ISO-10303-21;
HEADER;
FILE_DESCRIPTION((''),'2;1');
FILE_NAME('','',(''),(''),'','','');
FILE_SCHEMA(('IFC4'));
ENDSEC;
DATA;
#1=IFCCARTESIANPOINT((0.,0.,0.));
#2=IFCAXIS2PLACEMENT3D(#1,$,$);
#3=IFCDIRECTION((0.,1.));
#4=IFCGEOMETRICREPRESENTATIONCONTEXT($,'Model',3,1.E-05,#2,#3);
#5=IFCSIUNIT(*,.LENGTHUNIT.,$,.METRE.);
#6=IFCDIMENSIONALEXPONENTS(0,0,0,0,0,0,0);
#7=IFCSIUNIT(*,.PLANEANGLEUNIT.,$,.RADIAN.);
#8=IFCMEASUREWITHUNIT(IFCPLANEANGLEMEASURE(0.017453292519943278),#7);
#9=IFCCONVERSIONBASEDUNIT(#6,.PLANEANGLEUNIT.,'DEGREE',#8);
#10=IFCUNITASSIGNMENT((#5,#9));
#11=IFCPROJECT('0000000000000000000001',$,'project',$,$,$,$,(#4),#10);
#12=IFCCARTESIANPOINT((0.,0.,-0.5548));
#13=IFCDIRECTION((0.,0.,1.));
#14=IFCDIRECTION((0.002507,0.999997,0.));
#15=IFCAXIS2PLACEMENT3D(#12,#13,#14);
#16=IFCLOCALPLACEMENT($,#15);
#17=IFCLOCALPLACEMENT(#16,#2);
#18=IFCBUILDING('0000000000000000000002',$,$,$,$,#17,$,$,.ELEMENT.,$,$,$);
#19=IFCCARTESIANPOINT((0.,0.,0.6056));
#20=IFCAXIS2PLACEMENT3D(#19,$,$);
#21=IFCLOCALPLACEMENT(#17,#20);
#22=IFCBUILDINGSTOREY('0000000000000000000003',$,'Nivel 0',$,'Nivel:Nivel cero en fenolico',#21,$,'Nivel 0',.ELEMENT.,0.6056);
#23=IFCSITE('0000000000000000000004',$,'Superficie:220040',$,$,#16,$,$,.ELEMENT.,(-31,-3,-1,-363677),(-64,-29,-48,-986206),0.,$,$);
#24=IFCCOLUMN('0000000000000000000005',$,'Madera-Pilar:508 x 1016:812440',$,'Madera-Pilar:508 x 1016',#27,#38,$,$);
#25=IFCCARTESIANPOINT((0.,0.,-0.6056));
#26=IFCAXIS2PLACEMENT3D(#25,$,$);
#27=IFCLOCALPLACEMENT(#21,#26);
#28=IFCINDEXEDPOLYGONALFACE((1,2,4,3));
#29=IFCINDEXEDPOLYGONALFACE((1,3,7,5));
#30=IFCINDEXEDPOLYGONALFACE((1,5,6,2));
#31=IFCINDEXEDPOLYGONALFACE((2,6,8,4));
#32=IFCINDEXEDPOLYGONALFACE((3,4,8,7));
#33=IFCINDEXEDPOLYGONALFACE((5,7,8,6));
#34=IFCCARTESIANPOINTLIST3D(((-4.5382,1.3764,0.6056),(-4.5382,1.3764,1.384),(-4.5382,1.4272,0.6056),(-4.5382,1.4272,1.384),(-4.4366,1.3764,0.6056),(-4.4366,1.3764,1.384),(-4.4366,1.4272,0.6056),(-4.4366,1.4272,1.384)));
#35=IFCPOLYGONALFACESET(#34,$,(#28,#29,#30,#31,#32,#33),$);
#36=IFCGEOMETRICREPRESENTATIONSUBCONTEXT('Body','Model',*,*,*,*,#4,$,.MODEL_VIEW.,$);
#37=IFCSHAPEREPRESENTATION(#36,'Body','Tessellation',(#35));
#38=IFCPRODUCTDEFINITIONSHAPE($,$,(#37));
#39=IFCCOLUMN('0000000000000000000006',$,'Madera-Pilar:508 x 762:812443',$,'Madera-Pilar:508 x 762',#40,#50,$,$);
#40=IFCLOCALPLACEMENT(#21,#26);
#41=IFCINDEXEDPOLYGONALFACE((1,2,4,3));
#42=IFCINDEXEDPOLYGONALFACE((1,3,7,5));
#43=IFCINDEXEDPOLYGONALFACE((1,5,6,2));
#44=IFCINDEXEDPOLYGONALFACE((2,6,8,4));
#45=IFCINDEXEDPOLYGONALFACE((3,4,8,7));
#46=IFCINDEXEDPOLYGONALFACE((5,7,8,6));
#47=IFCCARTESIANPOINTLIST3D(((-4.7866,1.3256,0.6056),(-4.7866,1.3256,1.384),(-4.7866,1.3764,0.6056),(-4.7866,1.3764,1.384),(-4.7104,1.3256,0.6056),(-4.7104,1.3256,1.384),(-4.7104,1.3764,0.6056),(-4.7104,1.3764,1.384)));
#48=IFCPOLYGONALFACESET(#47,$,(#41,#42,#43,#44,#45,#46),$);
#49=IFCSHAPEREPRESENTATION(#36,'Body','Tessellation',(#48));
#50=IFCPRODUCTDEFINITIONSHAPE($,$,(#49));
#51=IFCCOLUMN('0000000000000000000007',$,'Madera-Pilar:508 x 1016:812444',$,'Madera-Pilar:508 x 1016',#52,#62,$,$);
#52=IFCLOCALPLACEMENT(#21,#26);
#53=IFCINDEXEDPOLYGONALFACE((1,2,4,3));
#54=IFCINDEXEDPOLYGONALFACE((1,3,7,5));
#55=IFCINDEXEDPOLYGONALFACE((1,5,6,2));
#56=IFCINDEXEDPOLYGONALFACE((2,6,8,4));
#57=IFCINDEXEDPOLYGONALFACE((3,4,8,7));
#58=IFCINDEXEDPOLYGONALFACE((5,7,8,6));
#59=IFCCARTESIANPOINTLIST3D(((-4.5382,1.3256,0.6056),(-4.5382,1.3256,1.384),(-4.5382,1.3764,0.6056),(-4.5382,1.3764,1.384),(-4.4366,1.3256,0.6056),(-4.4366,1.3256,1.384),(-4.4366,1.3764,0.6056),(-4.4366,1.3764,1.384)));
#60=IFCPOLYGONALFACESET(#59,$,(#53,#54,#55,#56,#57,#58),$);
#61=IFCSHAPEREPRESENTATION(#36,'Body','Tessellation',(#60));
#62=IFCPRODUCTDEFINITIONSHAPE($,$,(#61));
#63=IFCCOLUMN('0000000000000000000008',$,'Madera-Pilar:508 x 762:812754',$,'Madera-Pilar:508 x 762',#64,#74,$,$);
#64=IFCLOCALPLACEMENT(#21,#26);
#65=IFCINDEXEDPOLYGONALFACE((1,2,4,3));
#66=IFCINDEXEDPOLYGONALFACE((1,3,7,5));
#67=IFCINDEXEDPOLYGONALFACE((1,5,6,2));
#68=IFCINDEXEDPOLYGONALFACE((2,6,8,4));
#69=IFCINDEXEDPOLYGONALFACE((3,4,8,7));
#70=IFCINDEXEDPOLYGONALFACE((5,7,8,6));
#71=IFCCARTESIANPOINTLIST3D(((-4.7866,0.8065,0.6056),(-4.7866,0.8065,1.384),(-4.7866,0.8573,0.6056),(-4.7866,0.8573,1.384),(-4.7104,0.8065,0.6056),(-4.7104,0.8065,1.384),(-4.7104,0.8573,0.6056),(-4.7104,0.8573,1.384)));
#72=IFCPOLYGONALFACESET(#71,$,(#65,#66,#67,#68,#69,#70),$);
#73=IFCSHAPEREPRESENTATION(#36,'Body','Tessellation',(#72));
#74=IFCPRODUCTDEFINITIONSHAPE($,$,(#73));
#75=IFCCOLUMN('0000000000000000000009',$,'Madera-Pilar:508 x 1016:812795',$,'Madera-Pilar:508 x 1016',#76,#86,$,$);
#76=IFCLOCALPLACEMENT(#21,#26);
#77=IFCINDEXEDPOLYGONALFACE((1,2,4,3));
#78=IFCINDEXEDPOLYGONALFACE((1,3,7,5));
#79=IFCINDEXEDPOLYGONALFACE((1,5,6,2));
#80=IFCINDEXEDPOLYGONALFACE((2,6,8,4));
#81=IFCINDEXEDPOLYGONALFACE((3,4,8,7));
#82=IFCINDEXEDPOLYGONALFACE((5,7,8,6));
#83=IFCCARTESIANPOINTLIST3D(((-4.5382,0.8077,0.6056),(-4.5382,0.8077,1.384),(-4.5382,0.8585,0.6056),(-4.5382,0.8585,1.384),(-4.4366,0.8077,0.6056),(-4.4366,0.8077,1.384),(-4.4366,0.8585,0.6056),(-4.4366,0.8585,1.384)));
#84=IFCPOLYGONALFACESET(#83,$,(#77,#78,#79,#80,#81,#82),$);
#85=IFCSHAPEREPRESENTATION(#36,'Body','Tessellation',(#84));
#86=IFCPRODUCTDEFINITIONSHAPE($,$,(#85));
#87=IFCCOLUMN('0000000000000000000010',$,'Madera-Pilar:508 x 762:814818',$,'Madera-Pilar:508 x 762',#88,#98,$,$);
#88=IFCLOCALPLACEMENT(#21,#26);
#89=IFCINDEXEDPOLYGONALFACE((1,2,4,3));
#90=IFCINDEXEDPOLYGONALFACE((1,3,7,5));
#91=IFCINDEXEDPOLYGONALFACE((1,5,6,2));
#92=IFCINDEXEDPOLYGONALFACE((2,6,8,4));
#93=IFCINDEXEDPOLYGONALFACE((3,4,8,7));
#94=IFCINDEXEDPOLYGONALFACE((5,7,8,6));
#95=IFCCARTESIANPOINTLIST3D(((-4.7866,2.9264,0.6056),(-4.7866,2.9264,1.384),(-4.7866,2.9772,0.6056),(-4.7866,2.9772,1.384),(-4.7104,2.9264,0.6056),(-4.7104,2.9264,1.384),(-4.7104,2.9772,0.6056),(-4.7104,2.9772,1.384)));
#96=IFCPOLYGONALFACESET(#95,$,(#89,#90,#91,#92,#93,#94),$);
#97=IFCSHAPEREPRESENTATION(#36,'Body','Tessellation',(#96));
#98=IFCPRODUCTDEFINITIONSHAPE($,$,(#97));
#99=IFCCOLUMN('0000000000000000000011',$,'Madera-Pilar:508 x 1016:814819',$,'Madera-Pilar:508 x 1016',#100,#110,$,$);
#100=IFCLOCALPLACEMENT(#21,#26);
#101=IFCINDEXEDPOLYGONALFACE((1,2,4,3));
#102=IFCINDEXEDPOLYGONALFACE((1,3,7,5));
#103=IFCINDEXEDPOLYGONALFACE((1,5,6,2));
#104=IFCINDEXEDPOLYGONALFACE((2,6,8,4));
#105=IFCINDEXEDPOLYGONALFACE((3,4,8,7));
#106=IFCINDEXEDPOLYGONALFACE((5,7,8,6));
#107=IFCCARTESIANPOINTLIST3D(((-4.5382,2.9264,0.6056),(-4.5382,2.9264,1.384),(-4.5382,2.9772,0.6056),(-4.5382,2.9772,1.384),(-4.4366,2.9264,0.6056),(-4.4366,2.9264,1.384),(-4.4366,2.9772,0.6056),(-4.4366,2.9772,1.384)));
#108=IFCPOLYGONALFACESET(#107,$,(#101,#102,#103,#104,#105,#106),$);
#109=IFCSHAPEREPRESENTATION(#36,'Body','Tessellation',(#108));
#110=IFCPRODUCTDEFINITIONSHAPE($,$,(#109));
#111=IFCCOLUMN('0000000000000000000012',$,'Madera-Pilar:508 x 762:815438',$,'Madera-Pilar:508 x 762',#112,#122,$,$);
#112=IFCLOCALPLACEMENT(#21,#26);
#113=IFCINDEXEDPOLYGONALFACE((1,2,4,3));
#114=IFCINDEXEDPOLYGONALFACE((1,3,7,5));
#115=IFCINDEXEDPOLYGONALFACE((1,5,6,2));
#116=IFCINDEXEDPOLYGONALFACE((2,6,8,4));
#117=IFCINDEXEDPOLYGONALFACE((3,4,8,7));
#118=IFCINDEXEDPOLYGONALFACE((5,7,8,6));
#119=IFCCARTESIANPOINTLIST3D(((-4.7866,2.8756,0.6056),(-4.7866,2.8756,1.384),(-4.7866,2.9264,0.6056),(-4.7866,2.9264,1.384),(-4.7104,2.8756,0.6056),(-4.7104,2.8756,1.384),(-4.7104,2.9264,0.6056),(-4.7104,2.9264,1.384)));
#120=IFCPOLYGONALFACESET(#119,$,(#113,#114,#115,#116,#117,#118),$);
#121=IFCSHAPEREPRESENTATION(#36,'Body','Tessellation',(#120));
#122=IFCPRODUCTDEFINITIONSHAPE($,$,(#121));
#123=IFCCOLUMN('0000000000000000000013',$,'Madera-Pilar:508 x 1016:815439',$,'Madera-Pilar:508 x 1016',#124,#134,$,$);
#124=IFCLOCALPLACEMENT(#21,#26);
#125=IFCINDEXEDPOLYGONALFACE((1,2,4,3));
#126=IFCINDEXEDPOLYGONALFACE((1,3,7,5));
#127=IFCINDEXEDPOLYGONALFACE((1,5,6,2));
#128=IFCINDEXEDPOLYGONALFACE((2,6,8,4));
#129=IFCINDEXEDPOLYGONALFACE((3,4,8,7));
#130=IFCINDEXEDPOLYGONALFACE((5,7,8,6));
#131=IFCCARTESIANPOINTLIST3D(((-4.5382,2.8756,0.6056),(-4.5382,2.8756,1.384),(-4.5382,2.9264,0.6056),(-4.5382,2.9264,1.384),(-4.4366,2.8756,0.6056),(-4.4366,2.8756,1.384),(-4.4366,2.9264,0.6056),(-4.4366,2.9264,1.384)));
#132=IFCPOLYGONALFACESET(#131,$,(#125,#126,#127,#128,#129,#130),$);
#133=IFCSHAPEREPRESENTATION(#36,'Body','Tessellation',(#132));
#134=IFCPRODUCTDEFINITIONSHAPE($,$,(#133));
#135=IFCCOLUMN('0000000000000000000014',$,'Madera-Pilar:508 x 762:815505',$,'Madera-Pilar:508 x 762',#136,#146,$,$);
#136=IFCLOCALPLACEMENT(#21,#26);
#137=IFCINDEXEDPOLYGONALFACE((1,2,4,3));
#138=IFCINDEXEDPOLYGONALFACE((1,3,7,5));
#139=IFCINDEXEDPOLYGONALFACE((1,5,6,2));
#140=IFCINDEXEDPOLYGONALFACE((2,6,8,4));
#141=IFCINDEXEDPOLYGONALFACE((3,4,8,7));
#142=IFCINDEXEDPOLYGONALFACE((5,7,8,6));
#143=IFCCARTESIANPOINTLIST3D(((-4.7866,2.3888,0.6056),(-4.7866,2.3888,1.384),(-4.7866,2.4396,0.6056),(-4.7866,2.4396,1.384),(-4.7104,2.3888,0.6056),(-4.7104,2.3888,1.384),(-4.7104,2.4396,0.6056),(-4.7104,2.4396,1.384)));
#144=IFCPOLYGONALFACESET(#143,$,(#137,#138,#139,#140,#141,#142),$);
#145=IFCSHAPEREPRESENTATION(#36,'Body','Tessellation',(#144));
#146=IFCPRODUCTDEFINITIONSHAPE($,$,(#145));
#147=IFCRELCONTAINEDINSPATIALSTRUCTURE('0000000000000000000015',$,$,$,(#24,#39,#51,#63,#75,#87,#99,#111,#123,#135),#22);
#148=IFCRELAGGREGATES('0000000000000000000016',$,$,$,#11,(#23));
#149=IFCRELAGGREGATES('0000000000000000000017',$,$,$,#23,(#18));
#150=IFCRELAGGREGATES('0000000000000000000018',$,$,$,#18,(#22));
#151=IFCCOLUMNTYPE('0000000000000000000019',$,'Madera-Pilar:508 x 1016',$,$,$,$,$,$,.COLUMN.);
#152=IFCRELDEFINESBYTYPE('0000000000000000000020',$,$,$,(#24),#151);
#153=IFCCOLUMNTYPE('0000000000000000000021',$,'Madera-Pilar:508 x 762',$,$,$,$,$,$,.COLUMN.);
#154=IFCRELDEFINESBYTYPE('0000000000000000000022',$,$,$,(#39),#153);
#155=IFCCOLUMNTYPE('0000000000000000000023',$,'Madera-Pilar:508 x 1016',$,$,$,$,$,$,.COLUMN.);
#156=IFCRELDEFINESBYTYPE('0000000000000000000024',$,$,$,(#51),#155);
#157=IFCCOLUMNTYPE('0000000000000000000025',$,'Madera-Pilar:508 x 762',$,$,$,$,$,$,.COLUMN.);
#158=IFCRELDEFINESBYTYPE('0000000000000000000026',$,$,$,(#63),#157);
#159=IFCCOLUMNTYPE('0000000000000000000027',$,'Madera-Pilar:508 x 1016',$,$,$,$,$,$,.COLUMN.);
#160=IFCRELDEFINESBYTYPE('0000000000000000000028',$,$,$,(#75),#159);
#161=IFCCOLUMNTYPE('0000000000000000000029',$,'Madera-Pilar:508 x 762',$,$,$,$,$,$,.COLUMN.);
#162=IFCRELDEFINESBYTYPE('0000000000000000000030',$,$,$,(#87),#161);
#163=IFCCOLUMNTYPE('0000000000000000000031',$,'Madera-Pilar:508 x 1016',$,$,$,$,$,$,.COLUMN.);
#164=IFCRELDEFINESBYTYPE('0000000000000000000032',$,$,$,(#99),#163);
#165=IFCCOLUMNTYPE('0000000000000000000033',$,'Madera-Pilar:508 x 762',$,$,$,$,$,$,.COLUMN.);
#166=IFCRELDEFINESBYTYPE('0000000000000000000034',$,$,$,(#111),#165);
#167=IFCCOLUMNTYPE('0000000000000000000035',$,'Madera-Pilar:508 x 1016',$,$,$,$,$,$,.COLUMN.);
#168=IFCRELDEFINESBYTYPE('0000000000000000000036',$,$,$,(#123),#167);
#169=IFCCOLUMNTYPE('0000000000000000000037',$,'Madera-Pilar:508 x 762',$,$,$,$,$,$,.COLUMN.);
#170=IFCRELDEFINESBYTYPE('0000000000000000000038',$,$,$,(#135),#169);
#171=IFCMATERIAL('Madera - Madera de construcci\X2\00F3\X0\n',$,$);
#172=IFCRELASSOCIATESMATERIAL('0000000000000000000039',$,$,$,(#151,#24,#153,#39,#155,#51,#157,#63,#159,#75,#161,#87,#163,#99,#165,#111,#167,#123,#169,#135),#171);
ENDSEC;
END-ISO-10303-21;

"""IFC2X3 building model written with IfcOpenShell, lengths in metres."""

from ifc_helpers import new_model, entity, si_unit, converted_unit, direction, frame, frame_2d, origin, place, context, subcontext, project, spatial, rectangle, extrude, source, transform, mapped, material, type_object, type_shapes, element, save


model = new_model("IFC2X3")

# Units and contexts
model_context = context("Model", 3, precision=1e-05, world=origin(), true_north=direction((0.0, 1.0)))
body_context = subcontext(model_context, "Body", "Model", "MODEL_VIEW")
ifc_project = project(units=[si_unit("LENGTHUNIT", "METRE"), converted_unit("PLANEANGLEUNIT", "DEGREE", entity("IfcPlaneAngleMeasure", 0.017453292519943278), si_unit("PLANEANGLEUNIT", "RADIAN"), dimensions=[0, 0, 0, 0, 0, 0, 0])], contexts=[model_context])

# Site, building, storey
site_placement = place(None, frame((0.0, 0.0, -0.5548), z_axis=(0.0, 0.0, 1.0), x_axis=(0.002507, 0.999997, 0.0)))
site = spatial("IfcSite", under=ifc_project, at=site_placement, Name="Superficie:220040", CompositionType="ELEMENT", RefLatitude=(-31, -3, -1, -363677), RefLongitude=(-64, -29, -48, -986206), RefElevation=0.0)
building_placement = place(site_placement, origin())
building = spatial("IfcBuilding", under=site, at=building_placement, CompositionType="ELEMENT")
storey_placement = place(building_placement, frame((0.0, 0.0, 0.6056)))
storey = spatial("IfcBuildingStorey", under=building, at=storey_placement, Name="Nivel 0", ObjectType="Nivel:Nivel cero en fenolico", LongName="Nivel 0", CompositionType="ELEMENT", Elevation=0.6056)

# Columns
ifc_material = material(Name="Madera - Madera de construcción")
column_type_1 = type_object("IfcColumnType", Name="Madera-Pilar:508 x 1016", PredefinedType="COLUMN", material=ifc_material)
shared_shape_1 = source(origin(), body_context, "Body", "SweptSolid", [
    extrude(rectangle(XDim=0.1016, YDim=0.0508, at=frame_2d((0.0, 0.0), x_axis=(1.0, 0.0))), frame((-4.4874, 1.4018, 0.6056), z_axis=(0.0, 0.0, 1.0), x_axis=(-1.0, 0.0, 0.0)), (0.0, 0.0, 1.0), 0.7784),
])
type_shapes(column_type_1, [shared_shape_1])
column_1_placement = place(storey_placement, frame((0.0, 0.0, -0.6056)))
element("IfcColumn", 1, at=column_1_placement, inside=storey, type_object=column_type_1, material=ifc_material, Name="Madera-Pilar:508 x 1016:812440", ObjectType="Madera-Pilar:508 x 1016", context=body_context, shape_type="MappedRepresentation", body=[
    mapped(shared_shape_1, transform((0.0, 0.0, 0.0), scale=1.0)),
])
column_type_2 = type_object("IfcColumnType", Name="Madera-Pilar:508 x 762", PredefinedType="COLUMN", material=ifc_material)
shared_shape_2 = source(origin(), body_context, "Body", "SweptSolid", [
    extrude(rectangle(XDim=0.0762, YDim=0.0508, at=frame_2d((0.0, 0.0), x_axis=(1.0, 0.0))), frame((-4.7485, 1.351, 0.6056), z_axis=(0.0, 0.0, 1.0), x_axis=(-1.0, 0.0, 0.0)), (0.0, 0.0, 1.0), 0.7784),
])
type_shapes(column_type_2, [shared_shape_2])
column_2_placement = place(storey_placement, frame((0.0, 0.0, -0.6056)))
element("IfcColumn", 2, at=column_2_placement, inside=storey, type_object=column_type_2, material=ifc_material, Name="Madera-Pilar:508 x 762:812443", ObjectType="Madera-Pilar:508 x 762", context=body_context, shape_type="MappedRepresentation", body=[
    mapped(shared_shape_2, transform((0.0, 0.0, 0.0), scale=1.0)),
])
column_type_3 = type_object("IfcColumnType", Name="Madera-Pilar:508 x 1016", PredefinedType="COLUMN", material=ifc_material)
shared_shape_3 = source(origin(), body_context, "Body", "SweptSolid", [
    extrude(rectangle(XDim=0.1016, YDim=0.0508, at=frame_2d((0.0, 0.0), x_axis=(1.0, 0.0))), frame((-4.4874, 1.351, 0.6056), z_axis=(0.0, 0.0, 1.0), x_axis=(-1.0, 0.0, 0.0)), (0.0, 0.0, 1.0), 0.7784),
])
type_shapes(column_type_3, [shared_shape_3])
column_3_placement = place(storey_placement, frame((0.0, 0.0, -0.6056)))
element("IfcColumn", 3, at=column_3_placement, inside=storey, type_object=column_type_3, material=ifc_material, Name="Madera-Pilar:508 x 1016:812444", ObjectType="Madera-Pilar:508 x 1016", context=body_context, shape_type="MappedRepresentation", body=[
    mapped(shared_shape_3, transform((0.0, 0.0, 0.0), scale=1.0)),
])
column_type_4 = type_object("IfcColumnType", Name="Madera-Pilar:508 x 762", PredefinedType="COLUMN", material=ifc_material)
shared_shape_4 = source(origin(), body_context, "Body", "SweptSolid", [
    extrude(rectangle(XDim=0.0762, YDim=0.0508, at=frame_2d((0.0, 0.0), x_axis=(1.0, 0.0))), frame((-4.7485, 0.8319, 0.6056), z_axis=(0.0, 0.0, 1.0), x_axis=(-1.0, 0.0, 0.0)), (0.0, 0.0, 1.0), 0.7784),
])
type_shapes(column_type_4, [shared_shape_4])
column_4_placement = place(storey_placement, frame((0.0, 0.0, -0.6056)))
element("IfcColumn", 4, at=column_4_placement, inside=storey, type_object=column_type_4, material=ifc_material, Name="Madera-Pilar:508 x 762:812754", ObjectType="Madera-Pilar:508 x 762", context=body_context, shape_type="MappedRepresentation", body=[
    mapped(shared_shape_4, transform((0.0, 0.0, 0.0), scale=1.0)),
])
column_type_5 = type_object("IfcColumnType", Name="Madera-Pilar:508 x 1016", PredefinedType="COLUMN", material=ifc_material)
shared_shape_5 = source(origin(), body_context, "Body", "SweptSolid", [
    extrude(rectangle(XDim=0.1016, YDim=0.0508, at=frame_2d((0.0, 0.0), x_axis=(1.0, 0.0))), frame((-4.4874, 0.8331, 0.6056), z_axis=(0.0, 0.0, 1.0), x_axis=(-1.0, 0.0, 0.0)), (0.0, 0.0, 1.0), 0.7784),
])
type_shapes(column_type_5, [shared_shape_5])
column_5_placement = place(storey_placement, frame((0.0, 0.0, -0.6056)))
element("IfcColumn", 5, at=column_5_placement, inside=storey, type_object=column_type_5, material=ifc_material, Name="Madera-Pilar:508 x 1016:812795", ObjectType="Madera-Pilar:508 x 1016", context=body_context, shape_type="MappedRepresentation", body=[
    mapped(shared_shape_5, transform((0.0, 0.0, 0.0), scale=1.0)),
])
column_type_6 = type_object("IfcColumnType", Name="Madera-Pilar:508 x 762", PredefinedType="COLUMN", material=ifc_material)
shared_shape_6 = source(origin(), body_context, "Body", "SweptSolid", [
    extrude(rectangle(XDim=0.0762, YDim=0.0508, at=frame_2d((0.0, 0.0), x_axis=(1.0, 0.0))), frame((-4.7485, 2.9518, 0.6056), z_axis=(0.0, 0.0, 1.0), x_axis=(-1.0, 0.0, 0.0)), (0.0, 0.0, 1.0), 0.7784),
])
type_shapes(column_type_6, [shared_shape_6])
column_6_placement = place(storey_placement, frame((0.0, 0.0, -0.6056)))
element("IfcColumn", 6, at=column_6_placement, inside=storey, type_object=column_type_6, material=ifc_material, Name="Madera-Pilar:508 x 762:814818", ObjectType="Madera-Pilar:508 x 762", context=body_context, shape_type="MappedRepresentation", body=[
    mapped(shared_shape_6, transform((0.0, 0.0, 0.0), scale=1.0)),
])
column_type_7 = type_object("IfcColumnType", Name="Madera-Pilar:508 x 1016", PredefinedType="COLUMN", material=ifc_material)
shared_shape_7 = source(origin(), body_context, "Body", "SweptSolid", [
    extrude(rectangle(XDim=0.1016, YDim=0.0508, at=frame_2d((0.0, 0.0), x_axis=(1.0, 0.0))), frame((-4.4874, 2.9518, 0.6056), z_axis=(0.0, 0.0, 1.0), x_axis=(-1.0, 0.0, 0.0)), (0.0, 0.0, 1.0), 0.7784),
])
type_shapes(column_type_7, [shared_shape_7])
column_7_placement = place(storey_placement, frame((0.0, 0.0, -0.6056)))
element("IfcColumn", 7, at=column_7_placement, inside=storey, type_object=column_type_7, material=ifc_material, Name="Madera-Pilar:508 x 1016:814819", ObjectType="Madera-Pilar:508 x 1016", context=body_context, shape_type="MappedRepresentation", body=[
    mapped(shared_shape_7, transform((0.0, 0.0, 0.0), scale=1.0)),
])
column_type_8 = type_object("IfcColumnType", Name="Madera-Pilar:508 x 762", PredefinedType="COLUMN", material=ifc_material)
shared_shape_8 = source(origin(), body_context, "Body", "SweptSolid", [
    extrude(rectangle(XDim=0.0762, YDim=0.0508, at=frame_2d((0.0, 0.0), x_axis=(1.0, 0.0))), frame((-4.7485, 2.901, 0.6056), z_axis=(0.0, 0.0, 1.0), x_axis=(-1.0, 0.0, 0.0)), (0.0, 0.0, 1.0), 0.7784),
])
type_shapes(column_type_8, [shared_shape_8])
column_8_placement = place(storey_placement, frame((0.0, 0.0, -0.6056)))
element("IfcColumn", 8, at=column_8_placement, inside=storey, type_object=column_type_8, material=ifc_material, Name="Madera-Pilar:508 x 762:815438", ObjectType="Madera-Pilar:508 x 762", context=body_context, shape_type="MappedRepresentation", body=[
    mapped(shared_shape_8, transform((0.0, 0.0, 0.0), scale=1.0)),
])
column_type_9 = type_object("IfcColumnType", Name="Madera-Pilar:508 x 1016", PredefinedType="COLUMN", material=ifc_material)
shared_shape_9 = source(origin(), body_context, "Body", "SweptSolid", [
    extrude(rectangle(XDim=0.1016, YDim=0.0508, at=frame_2d((0.0, 0.0), x_axis=(1.0, 0.0))), frame((-4.4874, 2.901, 0.6056), z_axis=(0.0, 0.0, 1.0), x_axis=(-1.0, 0.0, 0.0)), (0.0, 0.0, 1.0), 0.7784),
])
type_shapes(column_type_9, [shared_shape_9])
column_9_placement = place(storey_placement, frame((0.0, 0.0, -0.6056)))
element("IfcColumn", 9, at=column_9_placement, inside=storey, type_object=column_type_9, material=ifc_material, Name="Madera-Pilar:508 x 1016:815439", ObjectType="Madera-Pilar:508 x 1016", context=body_context, shape_type="MappedRepresentation", body=[
    mapped(shared_shape_9, transform((0.0, 0.0, 0.0), scale=1.0)),
])
column_type_10 = type_object("IfcColumnType", Name="Madera-Pilar:508 x 762", PredefinedType="COLUMN", material=ifc_material)
shared_shape_10 = source(origin(), body_context, "Body", "SweptSolid", [
    extrude(rectangle(XDim=0.0762, YDim=0.0508, at=frame_2d((0.0, 0.0), x_axis=(1.0, 0.0))), frame((-4.7485, 2.4142, 0.6056), z_axis=(0.0, 0.0, 1.0), x_axis=(-1.0, 0.0, 0.0)), (0.0, 0.0, 1.0), 0.7784),
])
type_shapes(column_type_10, [shared_shape_10])
column_10_placement = place(storey_placement, frame((0.0, 0.0, -0.6056)))
element("IfcColumn", 10, at=column_10_placement, inside=storey, type_object=column_type_10, material=ifc_material, Name="Madera-Pilar:508 x 762:815505", ObjectType="Madera-Pilar:508 x 762", context=body_context, shape_type="MappedRepresentation", body=[
    mapped(shared_shape_10, transform((0.0, 0.0, 0.0), scale=1.0)),
])

save(model, "model.ifc")
